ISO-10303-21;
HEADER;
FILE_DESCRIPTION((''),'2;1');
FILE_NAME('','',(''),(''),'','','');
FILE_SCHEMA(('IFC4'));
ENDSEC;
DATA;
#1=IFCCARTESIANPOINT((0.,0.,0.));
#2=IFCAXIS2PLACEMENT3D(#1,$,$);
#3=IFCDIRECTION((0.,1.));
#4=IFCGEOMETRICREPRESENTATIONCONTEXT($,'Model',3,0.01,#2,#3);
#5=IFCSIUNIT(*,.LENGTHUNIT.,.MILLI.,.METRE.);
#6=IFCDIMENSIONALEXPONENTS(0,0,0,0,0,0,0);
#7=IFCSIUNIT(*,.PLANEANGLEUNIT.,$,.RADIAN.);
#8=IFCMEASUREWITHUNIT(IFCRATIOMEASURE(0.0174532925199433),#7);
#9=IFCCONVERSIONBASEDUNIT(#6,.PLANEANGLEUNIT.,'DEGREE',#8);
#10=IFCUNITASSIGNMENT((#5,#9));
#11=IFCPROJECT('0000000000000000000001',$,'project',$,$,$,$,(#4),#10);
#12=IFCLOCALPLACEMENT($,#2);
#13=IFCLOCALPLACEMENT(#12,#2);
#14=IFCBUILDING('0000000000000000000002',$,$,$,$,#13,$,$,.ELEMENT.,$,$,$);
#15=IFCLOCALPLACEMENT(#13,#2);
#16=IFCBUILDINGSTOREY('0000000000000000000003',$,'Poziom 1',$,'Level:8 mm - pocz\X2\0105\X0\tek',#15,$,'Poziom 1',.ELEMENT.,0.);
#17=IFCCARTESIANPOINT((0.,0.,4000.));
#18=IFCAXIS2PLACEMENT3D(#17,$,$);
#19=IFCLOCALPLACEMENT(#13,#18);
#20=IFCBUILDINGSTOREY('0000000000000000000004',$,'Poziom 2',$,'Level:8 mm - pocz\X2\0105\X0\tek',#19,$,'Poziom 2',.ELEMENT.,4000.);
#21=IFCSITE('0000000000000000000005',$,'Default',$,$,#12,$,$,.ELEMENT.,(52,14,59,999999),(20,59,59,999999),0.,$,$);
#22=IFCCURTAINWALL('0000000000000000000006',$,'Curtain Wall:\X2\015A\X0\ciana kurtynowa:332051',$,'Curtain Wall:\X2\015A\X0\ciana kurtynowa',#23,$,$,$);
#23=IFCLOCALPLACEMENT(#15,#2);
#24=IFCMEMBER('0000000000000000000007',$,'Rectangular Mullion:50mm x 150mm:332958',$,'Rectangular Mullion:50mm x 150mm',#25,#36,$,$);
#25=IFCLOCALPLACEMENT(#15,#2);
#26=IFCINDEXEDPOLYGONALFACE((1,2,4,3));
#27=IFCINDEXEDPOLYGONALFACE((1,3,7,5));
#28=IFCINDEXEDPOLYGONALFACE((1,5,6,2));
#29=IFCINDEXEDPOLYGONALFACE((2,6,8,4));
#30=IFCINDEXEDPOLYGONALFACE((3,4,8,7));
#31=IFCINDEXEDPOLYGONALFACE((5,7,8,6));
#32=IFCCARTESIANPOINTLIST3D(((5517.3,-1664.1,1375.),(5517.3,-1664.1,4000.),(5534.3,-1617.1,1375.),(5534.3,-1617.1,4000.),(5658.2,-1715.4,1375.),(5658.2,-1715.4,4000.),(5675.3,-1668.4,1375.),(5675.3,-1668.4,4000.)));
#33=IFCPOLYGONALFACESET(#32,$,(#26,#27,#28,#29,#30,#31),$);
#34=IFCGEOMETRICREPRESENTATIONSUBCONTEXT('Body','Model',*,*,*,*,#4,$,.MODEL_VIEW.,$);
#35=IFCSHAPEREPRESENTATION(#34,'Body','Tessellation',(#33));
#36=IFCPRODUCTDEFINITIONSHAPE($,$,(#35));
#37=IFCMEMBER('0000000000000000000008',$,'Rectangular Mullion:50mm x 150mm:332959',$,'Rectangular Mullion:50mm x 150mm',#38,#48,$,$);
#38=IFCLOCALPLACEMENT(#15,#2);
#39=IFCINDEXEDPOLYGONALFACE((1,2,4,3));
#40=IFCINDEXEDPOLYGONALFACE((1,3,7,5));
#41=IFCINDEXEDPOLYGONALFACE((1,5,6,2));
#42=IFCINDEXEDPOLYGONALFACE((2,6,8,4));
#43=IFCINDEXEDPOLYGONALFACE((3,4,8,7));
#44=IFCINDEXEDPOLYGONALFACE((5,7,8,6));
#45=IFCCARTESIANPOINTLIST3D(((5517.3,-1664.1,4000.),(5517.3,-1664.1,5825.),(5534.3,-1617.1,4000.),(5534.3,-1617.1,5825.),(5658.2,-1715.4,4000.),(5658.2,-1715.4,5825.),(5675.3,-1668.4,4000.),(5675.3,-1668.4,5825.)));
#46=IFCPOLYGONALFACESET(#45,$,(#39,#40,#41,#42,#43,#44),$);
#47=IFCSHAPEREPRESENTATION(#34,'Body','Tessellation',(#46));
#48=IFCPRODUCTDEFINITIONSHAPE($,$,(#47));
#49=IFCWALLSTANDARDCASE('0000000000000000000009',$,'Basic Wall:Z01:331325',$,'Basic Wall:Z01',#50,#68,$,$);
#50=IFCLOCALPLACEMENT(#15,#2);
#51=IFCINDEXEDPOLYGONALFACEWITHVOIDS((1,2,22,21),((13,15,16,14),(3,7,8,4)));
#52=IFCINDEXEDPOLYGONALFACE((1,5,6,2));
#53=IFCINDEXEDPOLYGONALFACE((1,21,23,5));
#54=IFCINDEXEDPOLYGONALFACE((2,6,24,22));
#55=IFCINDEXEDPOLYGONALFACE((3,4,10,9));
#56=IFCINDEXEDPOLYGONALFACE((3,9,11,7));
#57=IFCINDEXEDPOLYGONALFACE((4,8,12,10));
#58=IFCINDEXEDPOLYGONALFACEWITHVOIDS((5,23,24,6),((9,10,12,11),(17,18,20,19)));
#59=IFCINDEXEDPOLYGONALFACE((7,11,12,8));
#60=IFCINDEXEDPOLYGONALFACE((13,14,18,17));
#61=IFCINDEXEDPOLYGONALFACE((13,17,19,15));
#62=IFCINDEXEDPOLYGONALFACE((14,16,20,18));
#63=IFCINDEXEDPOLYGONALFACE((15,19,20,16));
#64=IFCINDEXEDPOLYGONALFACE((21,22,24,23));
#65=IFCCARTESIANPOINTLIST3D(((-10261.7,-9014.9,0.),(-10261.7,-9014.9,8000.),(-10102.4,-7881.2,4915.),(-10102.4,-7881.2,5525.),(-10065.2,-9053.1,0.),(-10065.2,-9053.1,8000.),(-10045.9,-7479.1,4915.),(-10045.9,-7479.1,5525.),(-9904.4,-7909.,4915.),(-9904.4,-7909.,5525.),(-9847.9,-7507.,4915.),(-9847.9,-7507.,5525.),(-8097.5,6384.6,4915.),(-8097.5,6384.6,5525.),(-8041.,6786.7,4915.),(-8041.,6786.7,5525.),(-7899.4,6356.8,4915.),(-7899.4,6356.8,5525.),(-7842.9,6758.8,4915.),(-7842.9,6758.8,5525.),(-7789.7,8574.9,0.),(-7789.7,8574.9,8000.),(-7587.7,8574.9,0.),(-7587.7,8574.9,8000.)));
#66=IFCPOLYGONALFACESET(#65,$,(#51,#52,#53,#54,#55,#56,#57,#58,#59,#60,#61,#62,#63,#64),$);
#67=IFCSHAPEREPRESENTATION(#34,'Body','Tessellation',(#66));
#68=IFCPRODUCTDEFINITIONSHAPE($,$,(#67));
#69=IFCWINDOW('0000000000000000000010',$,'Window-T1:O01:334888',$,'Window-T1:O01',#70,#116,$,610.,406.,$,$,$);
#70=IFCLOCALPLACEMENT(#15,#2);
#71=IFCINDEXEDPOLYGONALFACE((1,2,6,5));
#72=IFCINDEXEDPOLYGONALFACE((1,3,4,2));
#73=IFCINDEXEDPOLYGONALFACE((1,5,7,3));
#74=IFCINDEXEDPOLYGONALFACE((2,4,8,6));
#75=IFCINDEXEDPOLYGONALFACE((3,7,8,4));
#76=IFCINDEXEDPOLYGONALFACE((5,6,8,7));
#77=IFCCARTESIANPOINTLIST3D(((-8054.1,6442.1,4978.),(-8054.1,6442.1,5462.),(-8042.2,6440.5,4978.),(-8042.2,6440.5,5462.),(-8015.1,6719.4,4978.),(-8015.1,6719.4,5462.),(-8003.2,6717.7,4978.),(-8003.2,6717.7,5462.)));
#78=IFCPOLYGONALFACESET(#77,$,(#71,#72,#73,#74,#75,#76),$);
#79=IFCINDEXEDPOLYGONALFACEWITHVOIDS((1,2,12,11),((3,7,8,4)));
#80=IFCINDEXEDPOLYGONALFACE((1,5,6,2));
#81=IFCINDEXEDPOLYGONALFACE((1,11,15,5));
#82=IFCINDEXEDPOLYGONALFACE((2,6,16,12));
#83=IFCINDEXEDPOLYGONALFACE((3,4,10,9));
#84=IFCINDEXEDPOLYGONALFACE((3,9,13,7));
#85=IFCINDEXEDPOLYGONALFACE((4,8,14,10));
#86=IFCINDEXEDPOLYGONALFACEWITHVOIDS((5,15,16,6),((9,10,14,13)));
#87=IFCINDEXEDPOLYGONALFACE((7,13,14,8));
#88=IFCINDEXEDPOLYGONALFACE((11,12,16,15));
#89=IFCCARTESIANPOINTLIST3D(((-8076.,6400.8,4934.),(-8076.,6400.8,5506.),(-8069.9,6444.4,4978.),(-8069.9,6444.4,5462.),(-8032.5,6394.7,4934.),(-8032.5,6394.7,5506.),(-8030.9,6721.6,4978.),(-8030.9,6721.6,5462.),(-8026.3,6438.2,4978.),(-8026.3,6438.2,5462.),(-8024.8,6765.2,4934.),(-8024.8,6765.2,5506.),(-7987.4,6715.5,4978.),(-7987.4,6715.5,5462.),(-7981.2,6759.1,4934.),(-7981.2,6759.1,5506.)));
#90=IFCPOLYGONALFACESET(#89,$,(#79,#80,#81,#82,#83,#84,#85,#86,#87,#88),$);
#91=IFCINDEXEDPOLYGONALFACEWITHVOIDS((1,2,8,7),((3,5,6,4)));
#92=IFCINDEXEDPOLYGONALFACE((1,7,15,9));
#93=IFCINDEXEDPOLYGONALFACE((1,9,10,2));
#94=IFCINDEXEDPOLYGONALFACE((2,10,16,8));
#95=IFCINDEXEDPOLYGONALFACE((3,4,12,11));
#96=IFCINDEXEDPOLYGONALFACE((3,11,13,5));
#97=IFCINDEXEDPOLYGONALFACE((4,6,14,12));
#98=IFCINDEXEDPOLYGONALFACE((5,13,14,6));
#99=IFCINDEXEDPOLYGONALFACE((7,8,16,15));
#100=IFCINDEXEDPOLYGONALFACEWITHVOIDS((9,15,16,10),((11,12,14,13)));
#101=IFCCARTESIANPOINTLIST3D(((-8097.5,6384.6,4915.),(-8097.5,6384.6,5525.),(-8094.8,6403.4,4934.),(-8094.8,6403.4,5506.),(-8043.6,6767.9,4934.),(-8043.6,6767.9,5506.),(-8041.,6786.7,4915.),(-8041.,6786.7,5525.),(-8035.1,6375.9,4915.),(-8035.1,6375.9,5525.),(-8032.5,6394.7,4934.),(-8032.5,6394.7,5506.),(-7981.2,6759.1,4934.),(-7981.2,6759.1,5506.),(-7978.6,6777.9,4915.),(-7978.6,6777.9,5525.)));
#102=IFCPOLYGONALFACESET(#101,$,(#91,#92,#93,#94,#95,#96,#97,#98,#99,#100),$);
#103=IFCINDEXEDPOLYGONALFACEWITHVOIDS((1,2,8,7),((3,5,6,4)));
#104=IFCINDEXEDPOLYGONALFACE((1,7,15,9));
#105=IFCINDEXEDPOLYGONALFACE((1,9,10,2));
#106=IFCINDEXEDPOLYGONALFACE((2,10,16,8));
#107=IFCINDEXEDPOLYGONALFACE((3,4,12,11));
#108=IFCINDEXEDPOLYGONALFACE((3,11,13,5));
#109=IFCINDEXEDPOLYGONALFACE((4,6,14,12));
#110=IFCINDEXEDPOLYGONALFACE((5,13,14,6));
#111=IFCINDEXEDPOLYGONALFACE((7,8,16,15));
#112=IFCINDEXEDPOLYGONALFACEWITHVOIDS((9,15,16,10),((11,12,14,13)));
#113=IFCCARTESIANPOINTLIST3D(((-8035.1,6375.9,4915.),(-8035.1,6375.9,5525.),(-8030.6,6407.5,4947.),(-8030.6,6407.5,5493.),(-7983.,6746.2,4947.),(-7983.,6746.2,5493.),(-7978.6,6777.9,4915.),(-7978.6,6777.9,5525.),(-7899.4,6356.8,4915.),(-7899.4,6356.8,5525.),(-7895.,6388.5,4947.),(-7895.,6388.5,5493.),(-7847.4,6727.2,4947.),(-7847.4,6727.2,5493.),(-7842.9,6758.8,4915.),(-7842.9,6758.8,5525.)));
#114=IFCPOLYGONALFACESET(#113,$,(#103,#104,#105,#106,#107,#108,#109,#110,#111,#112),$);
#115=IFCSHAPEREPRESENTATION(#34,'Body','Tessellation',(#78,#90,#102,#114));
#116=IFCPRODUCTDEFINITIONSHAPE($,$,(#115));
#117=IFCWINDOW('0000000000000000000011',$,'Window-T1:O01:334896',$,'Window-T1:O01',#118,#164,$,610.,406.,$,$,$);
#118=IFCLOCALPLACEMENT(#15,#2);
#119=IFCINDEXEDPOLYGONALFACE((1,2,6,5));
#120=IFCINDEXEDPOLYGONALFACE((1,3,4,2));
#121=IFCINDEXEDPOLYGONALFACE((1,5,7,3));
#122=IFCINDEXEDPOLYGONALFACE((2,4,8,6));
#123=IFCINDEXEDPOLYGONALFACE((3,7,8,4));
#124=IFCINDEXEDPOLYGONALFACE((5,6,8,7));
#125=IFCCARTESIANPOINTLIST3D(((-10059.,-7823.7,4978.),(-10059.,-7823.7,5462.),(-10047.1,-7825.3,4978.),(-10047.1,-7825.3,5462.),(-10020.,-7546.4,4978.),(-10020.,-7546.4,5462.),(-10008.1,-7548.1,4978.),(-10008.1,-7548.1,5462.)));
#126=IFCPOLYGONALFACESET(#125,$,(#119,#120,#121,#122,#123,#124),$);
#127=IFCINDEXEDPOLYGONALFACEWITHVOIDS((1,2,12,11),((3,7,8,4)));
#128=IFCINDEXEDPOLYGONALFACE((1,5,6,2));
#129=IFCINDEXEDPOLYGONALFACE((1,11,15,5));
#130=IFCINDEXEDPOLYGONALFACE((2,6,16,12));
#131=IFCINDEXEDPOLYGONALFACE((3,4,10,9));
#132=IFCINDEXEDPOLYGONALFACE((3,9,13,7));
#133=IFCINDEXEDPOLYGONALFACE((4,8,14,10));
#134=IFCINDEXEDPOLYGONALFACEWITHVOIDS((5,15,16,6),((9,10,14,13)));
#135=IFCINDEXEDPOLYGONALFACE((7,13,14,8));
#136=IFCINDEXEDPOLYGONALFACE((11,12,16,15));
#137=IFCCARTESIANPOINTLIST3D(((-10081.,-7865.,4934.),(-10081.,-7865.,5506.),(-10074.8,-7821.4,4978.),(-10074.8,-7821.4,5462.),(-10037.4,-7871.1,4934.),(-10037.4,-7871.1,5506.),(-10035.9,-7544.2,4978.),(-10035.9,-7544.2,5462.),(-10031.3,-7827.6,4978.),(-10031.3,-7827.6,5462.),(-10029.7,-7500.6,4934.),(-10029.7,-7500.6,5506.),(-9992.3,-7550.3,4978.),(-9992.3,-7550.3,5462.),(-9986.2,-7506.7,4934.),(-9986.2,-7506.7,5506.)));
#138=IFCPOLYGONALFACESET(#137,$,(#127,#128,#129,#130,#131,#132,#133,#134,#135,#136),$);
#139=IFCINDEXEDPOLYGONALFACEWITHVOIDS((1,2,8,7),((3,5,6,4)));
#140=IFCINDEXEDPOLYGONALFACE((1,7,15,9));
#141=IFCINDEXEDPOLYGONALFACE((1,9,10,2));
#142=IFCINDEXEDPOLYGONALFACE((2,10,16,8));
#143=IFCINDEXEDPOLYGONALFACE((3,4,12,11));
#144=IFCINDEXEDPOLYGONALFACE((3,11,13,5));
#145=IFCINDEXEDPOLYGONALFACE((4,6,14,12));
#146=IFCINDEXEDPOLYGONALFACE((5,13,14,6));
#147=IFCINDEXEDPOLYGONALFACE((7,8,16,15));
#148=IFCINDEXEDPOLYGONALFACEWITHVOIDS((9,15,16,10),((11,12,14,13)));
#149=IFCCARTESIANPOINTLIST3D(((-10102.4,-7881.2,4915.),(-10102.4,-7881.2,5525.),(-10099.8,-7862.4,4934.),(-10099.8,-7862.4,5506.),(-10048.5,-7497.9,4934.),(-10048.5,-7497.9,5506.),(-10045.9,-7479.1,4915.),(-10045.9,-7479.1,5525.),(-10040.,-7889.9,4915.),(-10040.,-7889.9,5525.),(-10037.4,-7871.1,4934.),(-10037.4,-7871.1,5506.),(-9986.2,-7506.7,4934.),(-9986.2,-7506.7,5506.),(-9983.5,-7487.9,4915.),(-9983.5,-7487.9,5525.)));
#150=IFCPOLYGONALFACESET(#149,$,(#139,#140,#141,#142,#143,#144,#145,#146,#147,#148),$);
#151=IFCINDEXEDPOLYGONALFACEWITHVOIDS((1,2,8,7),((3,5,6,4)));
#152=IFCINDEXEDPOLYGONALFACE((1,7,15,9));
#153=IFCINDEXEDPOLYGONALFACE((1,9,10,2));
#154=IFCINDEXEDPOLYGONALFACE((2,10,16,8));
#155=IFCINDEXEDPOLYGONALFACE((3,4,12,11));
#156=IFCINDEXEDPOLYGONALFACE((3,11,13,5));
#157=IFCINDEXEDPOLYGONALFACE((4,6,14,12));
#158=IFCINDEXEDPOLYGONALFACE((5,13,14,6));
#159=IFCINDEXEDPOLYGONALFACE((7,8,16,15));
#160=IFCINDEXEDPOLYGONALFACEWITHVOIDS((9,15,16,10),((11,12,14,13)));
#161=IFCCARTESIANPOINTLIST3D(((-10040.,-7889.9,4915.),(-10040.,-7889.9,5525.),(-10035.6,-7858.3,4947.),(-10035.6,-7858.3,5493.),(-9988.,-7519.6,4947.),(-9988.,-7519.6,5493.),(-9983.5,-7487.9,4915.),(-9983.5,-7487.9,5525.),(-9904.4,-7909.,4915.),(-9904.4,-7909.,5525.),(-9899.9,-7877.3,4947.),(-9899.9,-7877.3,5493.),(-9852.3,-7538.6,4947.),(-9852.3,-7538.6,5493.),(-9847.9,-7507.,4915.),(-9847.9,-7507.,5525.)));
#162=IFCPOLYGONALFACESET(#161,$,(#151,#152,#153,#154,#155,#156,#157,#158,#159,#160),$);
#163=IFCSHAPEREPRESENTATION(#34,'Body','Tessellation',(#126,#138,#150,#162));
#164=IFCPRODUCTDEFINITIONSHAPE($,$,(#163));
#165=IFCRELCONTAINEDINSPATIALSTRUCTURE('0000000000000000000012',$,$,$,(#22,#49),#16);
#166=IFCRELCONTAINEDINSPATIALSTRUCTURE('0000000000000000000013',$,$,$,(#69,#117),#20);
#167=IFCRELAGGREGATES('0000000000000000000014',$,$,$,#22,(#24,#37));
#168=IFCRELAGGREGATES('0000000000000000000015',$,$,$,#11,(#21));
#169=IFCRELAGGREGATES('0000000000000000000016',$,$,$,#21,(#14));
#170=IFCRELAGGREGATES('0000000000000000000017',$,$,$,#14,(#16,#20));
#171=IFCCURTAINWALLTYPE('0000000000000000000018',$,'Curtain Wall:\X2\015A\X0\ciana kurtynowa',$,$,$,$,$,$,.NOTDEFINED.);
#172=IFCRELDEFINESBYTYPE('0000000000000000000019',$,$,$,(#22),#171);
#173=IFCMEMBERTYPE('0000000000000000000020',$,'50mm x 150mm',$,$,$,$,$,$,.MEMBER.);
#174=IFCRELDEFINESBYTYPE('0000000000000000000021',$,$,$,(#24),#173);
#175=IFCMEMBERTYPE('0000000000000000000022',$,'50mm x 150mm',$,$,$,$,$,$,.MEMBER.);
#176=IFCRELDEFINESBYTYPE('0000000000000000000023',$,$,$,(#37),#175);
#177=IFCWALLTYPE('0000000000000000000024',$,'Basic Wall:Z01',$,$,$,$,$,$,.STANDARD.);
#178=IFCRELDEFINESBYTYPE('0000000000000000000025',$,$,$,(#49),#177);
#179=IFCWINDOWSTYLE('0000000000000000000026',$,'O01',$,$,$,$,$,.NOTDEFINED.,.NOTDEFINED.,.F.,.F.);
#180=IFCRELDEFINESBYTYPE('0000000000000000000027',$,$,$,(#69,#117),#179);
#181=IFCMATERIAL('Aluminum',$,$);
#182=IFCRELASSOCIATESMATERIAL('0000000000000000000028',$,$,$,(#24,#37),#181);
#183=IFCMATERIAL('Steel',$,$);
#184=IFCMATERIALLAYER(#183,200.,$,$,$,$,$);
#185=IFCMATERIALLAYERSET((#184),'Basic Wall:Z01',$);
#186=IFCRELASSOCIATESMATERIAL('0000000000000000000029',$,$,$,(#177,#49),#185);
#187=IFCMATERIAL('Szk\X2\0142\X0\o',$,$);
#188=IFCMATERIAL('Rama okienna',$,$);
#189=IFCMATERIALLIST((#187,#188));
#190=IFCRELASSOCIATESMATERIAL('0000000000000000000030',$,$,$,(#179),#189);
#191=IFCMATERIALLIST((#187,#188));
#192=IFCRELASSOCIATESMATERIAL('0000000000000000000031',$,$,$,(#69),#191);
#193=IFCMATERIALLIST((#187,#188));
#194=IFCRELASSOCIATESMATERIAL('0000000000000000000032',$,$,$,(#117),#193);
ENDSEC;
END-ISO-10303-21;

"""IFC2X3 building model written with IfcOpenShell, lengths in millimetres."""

from ifc_helpers import new_model, entity, si_unit, converted_unit, direction, frame, frame_2d, origin, origin_2d_with_axis, place, context, subcontext, project, spatial, polyline, rectangle, outline, extrude, source, transform, mapped, material, material_list, layer, layer_set, layer_usage, type_object, type_shapes, element, fill, aggregate, save


model = new_model("IFC2X3")

# Units and contexts
model_context = context("Model", 3, precision=0.01, world=origin(), true_north=direction((0.0, 1.0)))
body_context = subcontext(model_context, "Body", "Model", "MODEL_VIEW")
ifc_project = project(units=[si_unit("LENGTHUNIT", "METRE", prefix="MILLI"), converted_unit("PLANEANGLEUNIT", "DEGREE", entity("IfcRatioMeasure", 0.0174532925199433), si_unit("PLANEANGLEUNIT", "RADIAN"), dimensions=[0, 0, 0, 0, 0, 0, 0])], contexts=[model_context])

# Site, building, storey
site_placement = place(None, origin())
site = spatial("IfcSite", under=ifc_project, at=site_placement, Name="Default", CompositionType="ELEMENT", RefLatitude=(52, 14, 59, 999999), RefLongitude=(20, 59, 59, 999999), RefElevation=0.0)
building_placement = place(site_placement, origin())
building = spatial("IfcBuilding", under=site, at=building_placement, CompositionType="ELEMENT")
storey_1_placement = place(building_placement, origin())
storey_1 = spatial("IfcBuildingStorey", under=building, at=storey_1_placement, Name="Poziom 1", ObjectType="Level:8 mm - początek", LongName="Poziom 1", CompositionType="ELEMENT", Elevation=0.0)

# Curtain wall, members
curtain_wall_type = type_object("IfcCurtainWallType", Name="Curtain Wall:Ściana kurtynowa", PredefinedType="NOTDEFINED")
curtain_wall_placement = place(storey_1_placement, origin())
curtain_wall = element("IfcCurtainWall", 1, at=curtain_wall_placement, inside=storey_1, type_object=curtain_wall_type, Name="Curtain Wall:Ściana kurtynowa:332051", ObjectType="Curtain Wall:Ściana kurtynowa")
ifc_material_1 = material(Name="Aluminum")
member_type_1 = type_object("IfcMemberType", Name="50mm x 150mm", PredefinedType="MEMBER")
shared_shape_1 = source(origin(), body_context, "Body", "SweptSolid", [
    extrude(rectangle(XDim=150.0, YDim=50.0, at=origin_2d_with_axis()), frame((0.0, 0.0, -2625.0), z_axis=(0.0, 0.0, 1.0), x_axis=(0.0, -1.0, 0.0)), (0.0, 0.0, 1.0), 2625.0),
])
type_shapes(member_type_1, [shared_shape_1])
member_1_placement = place(storey_1_placement, frame((5596.3, -1666.3, 1375.0), z_axis=(0.0, 0.0, -1.0), x_axis=(0.341586, 0.939851, 0.0)))
member_1 = element("IfcMember", 2, at=member_1_placement, type_object=member_type_1, material=ifc_material_1, Name="Rectangular Mullion:50mm x 150mm:332958", ObjectType="Rectangular Mullion:50mm x 150mm", context=body_context, shape_type="MappedRepresentation", body=[
    mapped(shared_shape_1, transform((0.0, 0.0, 0.0), scale=1.0)),
])
member_type_2 = type_object("IfcMemberType", Name="50mm x 150mm", PredefinedType="MEMBER")
shared_shape_2 = source(origin(), body_context, "Body", "SweptSolid", [
    extrude(rectangle(XDim=150.0, YDim=50.0, at=origin_2d_with_axis()), frame((0.0, 0.0, -1825.0), z_axis=(0.0, 0.0, 1.0), x_axis=(0.0, -1.0, 0.0)), (0.0, 0.0, 1.0), 1825.0),
])
type_shapes(member_type_2, [shared_shape_2])
member_2_placement = place(storey_1_placement, frame((5596.3, -1666.3, 4000.0), z_axis=(0.0, 0.0, -1.0), x_axis=(0.341586, 0.939851, 0.0)))
member_2 = element("IfcMember", 3, at=member_2_placement, type_object=member_type_2, material=ifc_material_1, Name="Rectangular Mullion:50mm x 150mm:332959", ObjectType="Rectangular Mullion:50mm x 150mm", context=body_context, shape_type="MappedRepresentation", body=[
    mapped(shared_shape_2, transform((0.0, 0.0, 0.0), scale=1.0)),
])

aggregate(curtain_wall, [member_1, member_2])

# Wall, openings
ifc_material_2 = material(Name="Steel")
ifc_layer_1 = layer(ifc_material_2, 200.0)
ifc_layer_set_1 = layer_set([ifc_layer_1], Name="Basic Wall:Z01")
ifc_layer_usage_1 = layer_usage(ifc_layer_set_1, "AXIS2", "NEGATIVE", 100.0)
wall_type_1 = type_object("IfcWallType", Name="Basic Wall:Z01", PredefinedType="STANDARD", material=ifc_layer_set_1)
wall_1_placement = place(storey_1_placement, frame((-7686.7, 8588.8, 0.0), z_axis=(0.0, 0.0, 1.0), x_axis=(-0.139173, -0.990268, 0.0)))
wall_1 = element("IfcWallStandardCase", 4, at=wall_1_placement, inside=storey_1, type_object=wall_type_1, material=ifc_layer_usage_1, Name="Basic Wall:Z01:331325", ObjectType="Basic Wall:Z01", context=body_context, shape_type="SweptSolid", body=[
    extrude(outline(polyline([(17790.8, -100.0), (17801.2, 100.0), (17300.6, 100.0), (504.9, 100.0), (0.0, 100.0), (28.1, -100.0), (17790.8, -100.0)])), origin(), (0.0, 0.0, 1.0), 8000.0),
])
opening_1_placement = place(wall_1_placement, frame((2239.9, 100.0, 4915.0)))
opening_1 = element("IfcOpeningElement", 5, at=opening_1_placement, cuts=wall_1, ObjectType="Opening", context=body_context, shape_type="SweptSolid", body=[
    extrude(rectangle(XDim=610.0, YDim=406.0, at=frame_2d((305.0, 203.0), x_axis=(1.0, 0.0))), frame((0.0, 0.0, 0.0), z_axis=(0.0, -1.0, 0.0), x_axis=(0.0, 0.0, 1.0)), (0.0, 0.0, 1.0), 200.0),
])
opening_2_placement = place(wall_1_placement, frame((16645.9, 100.0, 4915.0)))
opening_2 = element("IfcOpeningElement", 6, at=opening_2_placement, cuts=wall_1, ObjectType="Opening", context=body_context, shape_type="SweptSolid", body=[
    extrude(rectangle(XDim=610.0, YDim=406.0, at=frame_2d((305.0, 203.0), x_axis=(1.0, 0.0))), frame((0.0, 0.0, 0.0), z_axis=(0.0, -1.0, 0.0), x_axis=(0.0, 0.0, 1.0)), (0.0, 0.0, 1.0), 200.0),
])

# Shared definitions
storey_2_placement = place(building_placement, frame((0.0, 0.0, 4000.0)))
storey_2 = spatial("IfcBuildingStorey", under=building, at=storey_2_placement, Name="Poziom 2", ObjectType="Level:8 mm - początek", LongName="Poziom 2", CompositionType="ELEMENT", Elevation=4000.0)

# Windows
ifc_material_3 = material(Name="Szkło")
ifc_material_4 = material(Name="Rama okienna")
ifc_material_list_1 = material_list([ifc_material_3, ifc_material_4])
ifc_material_list_2 = material_list([ifc_material_3, ifc_material_4])
window_style = type_object("IfcWindowStyle", Name="O01", ConstructionType="NOTDEFINED", OperationType="NOTDEFINED", ParameterTakesPrecedence=False, Sizeable=False, material=ifc_material_list_2)
shared_shape_3 = source(origin(), body_context, "Body", "SweptSolid", [
    extrude(rectangle(XDim=12.0, YDim=280.0, at=frame_2d((0.0, 0.0), x_axis=(1.0, 0.0))), frame((203.0, 159.0, 63.0), z_axis=(0.0, 0.0, 1.0), x_axis=(0.0, -1.0, 0.0)), (0.0, 0.0, 1.0), 484.0),
    extrude(outline(polyline([(-184.0, -286.0), (184.0, -286.0), (184.0, 286.0), (-184.0, 286.0), (-184.0, -286.0)]), holes=[polyline([(-140.0, -242.0), (-140.0, 242.0), (140.0, 242.0), (140.0, -242.0), (-140.0, -242.0)])]), frame((203.0, 137.0, 305.0), z_axis=(0.0, 1.0, 0.0), x_axis=(1.0, 0.0, 0.0)), (0.0, 0.0, 1.0), 44.0),
    extrude(outline(polyline([(-203.0, -305.0), (203.0, -305.0), (203.0, 305.0), (-203.0, 305.0), (-203.0, -305.0)]), holes=[polyline([(-184.0, -286.0), (-184.0, 286.0), (184.0, 286.0), (184.0, -286.0), (-184.0, -286.0)])]), frame((203.0, 137.0, 305.0), z_axis=(0.0, 1.0, 0.0), x_axis=(1.0, 0.0, 0.0)), (0.0, 0.0, 1.0), 63.0),
    extrude(outline(polyline([(-203.0, -305.0), (203.0, -305.0), (203.0, 305.0), (-203.0, 305.0), (-203.0, -305.0)]), holes=[polyline([(-171.0, -273.0), (-171.0, 273.0), (171.0, 273.0), (171.0, -273.0), (-171.0, -273.0)])]), frame((203.0, 0.0, 305.0), z_axis=(0.0, 1.0, 0.0), x_axis=(1.0, 0.0, 0.0)), (0.0, 0.0, 1.0), 137.0),
])
type_shapes(window_style, [shared_shape_3])
window_1_placement = place(opening_1_placement, frame((0.0, 0.0, 0.0), z_axis=(0.0, 0.0, 1.0), x_axis=(-1.0, 0.0, 0.0)))
window_1 = element("IfcWindow", 7, at=window_1_placement, inside=storey_2, type_object=window_style, material=ifc_material_list_1, Name="Window-T1:O01:334888", ObjectType="Window-T1:O01", OverallHeight=610.0, OverallWidth=406.0, context=body_context, shape_type="MappedRepresentation", body=[
    mapped(shared_shape_3, transform((0.0, 0.0, 0.0), scale=1.0)),
])
fill(opening_1, window_1)
ifc_material_list_3 = material_list([ifc_material_3, ifc_material_4])
window_2_placement = place(opening_2_placement, frame((0.0, 0.0, 0.0), z_axis=(0.0, 0.0, 1.0), x_axis=(-1.0, 0.0, 0.0)))
window_2 = element("IfcWindow", 8, at=window_2_placement, inside=storey_2, type_object=window_style, material=ifc_material_list_3, Name="Window-T1:O01:334896", ObjectType="Window-T1:O01", OverallHeight=610.0, OverallWidth=406.0, context=body_context, shape_type="MappedRepresentation", body=[
    mapped(shared_shape_3, transform((0.0, 0.0, 0.0), scale=1.0)),
])
fill(opening_2, window_2)

save(model, "model.ifc")
